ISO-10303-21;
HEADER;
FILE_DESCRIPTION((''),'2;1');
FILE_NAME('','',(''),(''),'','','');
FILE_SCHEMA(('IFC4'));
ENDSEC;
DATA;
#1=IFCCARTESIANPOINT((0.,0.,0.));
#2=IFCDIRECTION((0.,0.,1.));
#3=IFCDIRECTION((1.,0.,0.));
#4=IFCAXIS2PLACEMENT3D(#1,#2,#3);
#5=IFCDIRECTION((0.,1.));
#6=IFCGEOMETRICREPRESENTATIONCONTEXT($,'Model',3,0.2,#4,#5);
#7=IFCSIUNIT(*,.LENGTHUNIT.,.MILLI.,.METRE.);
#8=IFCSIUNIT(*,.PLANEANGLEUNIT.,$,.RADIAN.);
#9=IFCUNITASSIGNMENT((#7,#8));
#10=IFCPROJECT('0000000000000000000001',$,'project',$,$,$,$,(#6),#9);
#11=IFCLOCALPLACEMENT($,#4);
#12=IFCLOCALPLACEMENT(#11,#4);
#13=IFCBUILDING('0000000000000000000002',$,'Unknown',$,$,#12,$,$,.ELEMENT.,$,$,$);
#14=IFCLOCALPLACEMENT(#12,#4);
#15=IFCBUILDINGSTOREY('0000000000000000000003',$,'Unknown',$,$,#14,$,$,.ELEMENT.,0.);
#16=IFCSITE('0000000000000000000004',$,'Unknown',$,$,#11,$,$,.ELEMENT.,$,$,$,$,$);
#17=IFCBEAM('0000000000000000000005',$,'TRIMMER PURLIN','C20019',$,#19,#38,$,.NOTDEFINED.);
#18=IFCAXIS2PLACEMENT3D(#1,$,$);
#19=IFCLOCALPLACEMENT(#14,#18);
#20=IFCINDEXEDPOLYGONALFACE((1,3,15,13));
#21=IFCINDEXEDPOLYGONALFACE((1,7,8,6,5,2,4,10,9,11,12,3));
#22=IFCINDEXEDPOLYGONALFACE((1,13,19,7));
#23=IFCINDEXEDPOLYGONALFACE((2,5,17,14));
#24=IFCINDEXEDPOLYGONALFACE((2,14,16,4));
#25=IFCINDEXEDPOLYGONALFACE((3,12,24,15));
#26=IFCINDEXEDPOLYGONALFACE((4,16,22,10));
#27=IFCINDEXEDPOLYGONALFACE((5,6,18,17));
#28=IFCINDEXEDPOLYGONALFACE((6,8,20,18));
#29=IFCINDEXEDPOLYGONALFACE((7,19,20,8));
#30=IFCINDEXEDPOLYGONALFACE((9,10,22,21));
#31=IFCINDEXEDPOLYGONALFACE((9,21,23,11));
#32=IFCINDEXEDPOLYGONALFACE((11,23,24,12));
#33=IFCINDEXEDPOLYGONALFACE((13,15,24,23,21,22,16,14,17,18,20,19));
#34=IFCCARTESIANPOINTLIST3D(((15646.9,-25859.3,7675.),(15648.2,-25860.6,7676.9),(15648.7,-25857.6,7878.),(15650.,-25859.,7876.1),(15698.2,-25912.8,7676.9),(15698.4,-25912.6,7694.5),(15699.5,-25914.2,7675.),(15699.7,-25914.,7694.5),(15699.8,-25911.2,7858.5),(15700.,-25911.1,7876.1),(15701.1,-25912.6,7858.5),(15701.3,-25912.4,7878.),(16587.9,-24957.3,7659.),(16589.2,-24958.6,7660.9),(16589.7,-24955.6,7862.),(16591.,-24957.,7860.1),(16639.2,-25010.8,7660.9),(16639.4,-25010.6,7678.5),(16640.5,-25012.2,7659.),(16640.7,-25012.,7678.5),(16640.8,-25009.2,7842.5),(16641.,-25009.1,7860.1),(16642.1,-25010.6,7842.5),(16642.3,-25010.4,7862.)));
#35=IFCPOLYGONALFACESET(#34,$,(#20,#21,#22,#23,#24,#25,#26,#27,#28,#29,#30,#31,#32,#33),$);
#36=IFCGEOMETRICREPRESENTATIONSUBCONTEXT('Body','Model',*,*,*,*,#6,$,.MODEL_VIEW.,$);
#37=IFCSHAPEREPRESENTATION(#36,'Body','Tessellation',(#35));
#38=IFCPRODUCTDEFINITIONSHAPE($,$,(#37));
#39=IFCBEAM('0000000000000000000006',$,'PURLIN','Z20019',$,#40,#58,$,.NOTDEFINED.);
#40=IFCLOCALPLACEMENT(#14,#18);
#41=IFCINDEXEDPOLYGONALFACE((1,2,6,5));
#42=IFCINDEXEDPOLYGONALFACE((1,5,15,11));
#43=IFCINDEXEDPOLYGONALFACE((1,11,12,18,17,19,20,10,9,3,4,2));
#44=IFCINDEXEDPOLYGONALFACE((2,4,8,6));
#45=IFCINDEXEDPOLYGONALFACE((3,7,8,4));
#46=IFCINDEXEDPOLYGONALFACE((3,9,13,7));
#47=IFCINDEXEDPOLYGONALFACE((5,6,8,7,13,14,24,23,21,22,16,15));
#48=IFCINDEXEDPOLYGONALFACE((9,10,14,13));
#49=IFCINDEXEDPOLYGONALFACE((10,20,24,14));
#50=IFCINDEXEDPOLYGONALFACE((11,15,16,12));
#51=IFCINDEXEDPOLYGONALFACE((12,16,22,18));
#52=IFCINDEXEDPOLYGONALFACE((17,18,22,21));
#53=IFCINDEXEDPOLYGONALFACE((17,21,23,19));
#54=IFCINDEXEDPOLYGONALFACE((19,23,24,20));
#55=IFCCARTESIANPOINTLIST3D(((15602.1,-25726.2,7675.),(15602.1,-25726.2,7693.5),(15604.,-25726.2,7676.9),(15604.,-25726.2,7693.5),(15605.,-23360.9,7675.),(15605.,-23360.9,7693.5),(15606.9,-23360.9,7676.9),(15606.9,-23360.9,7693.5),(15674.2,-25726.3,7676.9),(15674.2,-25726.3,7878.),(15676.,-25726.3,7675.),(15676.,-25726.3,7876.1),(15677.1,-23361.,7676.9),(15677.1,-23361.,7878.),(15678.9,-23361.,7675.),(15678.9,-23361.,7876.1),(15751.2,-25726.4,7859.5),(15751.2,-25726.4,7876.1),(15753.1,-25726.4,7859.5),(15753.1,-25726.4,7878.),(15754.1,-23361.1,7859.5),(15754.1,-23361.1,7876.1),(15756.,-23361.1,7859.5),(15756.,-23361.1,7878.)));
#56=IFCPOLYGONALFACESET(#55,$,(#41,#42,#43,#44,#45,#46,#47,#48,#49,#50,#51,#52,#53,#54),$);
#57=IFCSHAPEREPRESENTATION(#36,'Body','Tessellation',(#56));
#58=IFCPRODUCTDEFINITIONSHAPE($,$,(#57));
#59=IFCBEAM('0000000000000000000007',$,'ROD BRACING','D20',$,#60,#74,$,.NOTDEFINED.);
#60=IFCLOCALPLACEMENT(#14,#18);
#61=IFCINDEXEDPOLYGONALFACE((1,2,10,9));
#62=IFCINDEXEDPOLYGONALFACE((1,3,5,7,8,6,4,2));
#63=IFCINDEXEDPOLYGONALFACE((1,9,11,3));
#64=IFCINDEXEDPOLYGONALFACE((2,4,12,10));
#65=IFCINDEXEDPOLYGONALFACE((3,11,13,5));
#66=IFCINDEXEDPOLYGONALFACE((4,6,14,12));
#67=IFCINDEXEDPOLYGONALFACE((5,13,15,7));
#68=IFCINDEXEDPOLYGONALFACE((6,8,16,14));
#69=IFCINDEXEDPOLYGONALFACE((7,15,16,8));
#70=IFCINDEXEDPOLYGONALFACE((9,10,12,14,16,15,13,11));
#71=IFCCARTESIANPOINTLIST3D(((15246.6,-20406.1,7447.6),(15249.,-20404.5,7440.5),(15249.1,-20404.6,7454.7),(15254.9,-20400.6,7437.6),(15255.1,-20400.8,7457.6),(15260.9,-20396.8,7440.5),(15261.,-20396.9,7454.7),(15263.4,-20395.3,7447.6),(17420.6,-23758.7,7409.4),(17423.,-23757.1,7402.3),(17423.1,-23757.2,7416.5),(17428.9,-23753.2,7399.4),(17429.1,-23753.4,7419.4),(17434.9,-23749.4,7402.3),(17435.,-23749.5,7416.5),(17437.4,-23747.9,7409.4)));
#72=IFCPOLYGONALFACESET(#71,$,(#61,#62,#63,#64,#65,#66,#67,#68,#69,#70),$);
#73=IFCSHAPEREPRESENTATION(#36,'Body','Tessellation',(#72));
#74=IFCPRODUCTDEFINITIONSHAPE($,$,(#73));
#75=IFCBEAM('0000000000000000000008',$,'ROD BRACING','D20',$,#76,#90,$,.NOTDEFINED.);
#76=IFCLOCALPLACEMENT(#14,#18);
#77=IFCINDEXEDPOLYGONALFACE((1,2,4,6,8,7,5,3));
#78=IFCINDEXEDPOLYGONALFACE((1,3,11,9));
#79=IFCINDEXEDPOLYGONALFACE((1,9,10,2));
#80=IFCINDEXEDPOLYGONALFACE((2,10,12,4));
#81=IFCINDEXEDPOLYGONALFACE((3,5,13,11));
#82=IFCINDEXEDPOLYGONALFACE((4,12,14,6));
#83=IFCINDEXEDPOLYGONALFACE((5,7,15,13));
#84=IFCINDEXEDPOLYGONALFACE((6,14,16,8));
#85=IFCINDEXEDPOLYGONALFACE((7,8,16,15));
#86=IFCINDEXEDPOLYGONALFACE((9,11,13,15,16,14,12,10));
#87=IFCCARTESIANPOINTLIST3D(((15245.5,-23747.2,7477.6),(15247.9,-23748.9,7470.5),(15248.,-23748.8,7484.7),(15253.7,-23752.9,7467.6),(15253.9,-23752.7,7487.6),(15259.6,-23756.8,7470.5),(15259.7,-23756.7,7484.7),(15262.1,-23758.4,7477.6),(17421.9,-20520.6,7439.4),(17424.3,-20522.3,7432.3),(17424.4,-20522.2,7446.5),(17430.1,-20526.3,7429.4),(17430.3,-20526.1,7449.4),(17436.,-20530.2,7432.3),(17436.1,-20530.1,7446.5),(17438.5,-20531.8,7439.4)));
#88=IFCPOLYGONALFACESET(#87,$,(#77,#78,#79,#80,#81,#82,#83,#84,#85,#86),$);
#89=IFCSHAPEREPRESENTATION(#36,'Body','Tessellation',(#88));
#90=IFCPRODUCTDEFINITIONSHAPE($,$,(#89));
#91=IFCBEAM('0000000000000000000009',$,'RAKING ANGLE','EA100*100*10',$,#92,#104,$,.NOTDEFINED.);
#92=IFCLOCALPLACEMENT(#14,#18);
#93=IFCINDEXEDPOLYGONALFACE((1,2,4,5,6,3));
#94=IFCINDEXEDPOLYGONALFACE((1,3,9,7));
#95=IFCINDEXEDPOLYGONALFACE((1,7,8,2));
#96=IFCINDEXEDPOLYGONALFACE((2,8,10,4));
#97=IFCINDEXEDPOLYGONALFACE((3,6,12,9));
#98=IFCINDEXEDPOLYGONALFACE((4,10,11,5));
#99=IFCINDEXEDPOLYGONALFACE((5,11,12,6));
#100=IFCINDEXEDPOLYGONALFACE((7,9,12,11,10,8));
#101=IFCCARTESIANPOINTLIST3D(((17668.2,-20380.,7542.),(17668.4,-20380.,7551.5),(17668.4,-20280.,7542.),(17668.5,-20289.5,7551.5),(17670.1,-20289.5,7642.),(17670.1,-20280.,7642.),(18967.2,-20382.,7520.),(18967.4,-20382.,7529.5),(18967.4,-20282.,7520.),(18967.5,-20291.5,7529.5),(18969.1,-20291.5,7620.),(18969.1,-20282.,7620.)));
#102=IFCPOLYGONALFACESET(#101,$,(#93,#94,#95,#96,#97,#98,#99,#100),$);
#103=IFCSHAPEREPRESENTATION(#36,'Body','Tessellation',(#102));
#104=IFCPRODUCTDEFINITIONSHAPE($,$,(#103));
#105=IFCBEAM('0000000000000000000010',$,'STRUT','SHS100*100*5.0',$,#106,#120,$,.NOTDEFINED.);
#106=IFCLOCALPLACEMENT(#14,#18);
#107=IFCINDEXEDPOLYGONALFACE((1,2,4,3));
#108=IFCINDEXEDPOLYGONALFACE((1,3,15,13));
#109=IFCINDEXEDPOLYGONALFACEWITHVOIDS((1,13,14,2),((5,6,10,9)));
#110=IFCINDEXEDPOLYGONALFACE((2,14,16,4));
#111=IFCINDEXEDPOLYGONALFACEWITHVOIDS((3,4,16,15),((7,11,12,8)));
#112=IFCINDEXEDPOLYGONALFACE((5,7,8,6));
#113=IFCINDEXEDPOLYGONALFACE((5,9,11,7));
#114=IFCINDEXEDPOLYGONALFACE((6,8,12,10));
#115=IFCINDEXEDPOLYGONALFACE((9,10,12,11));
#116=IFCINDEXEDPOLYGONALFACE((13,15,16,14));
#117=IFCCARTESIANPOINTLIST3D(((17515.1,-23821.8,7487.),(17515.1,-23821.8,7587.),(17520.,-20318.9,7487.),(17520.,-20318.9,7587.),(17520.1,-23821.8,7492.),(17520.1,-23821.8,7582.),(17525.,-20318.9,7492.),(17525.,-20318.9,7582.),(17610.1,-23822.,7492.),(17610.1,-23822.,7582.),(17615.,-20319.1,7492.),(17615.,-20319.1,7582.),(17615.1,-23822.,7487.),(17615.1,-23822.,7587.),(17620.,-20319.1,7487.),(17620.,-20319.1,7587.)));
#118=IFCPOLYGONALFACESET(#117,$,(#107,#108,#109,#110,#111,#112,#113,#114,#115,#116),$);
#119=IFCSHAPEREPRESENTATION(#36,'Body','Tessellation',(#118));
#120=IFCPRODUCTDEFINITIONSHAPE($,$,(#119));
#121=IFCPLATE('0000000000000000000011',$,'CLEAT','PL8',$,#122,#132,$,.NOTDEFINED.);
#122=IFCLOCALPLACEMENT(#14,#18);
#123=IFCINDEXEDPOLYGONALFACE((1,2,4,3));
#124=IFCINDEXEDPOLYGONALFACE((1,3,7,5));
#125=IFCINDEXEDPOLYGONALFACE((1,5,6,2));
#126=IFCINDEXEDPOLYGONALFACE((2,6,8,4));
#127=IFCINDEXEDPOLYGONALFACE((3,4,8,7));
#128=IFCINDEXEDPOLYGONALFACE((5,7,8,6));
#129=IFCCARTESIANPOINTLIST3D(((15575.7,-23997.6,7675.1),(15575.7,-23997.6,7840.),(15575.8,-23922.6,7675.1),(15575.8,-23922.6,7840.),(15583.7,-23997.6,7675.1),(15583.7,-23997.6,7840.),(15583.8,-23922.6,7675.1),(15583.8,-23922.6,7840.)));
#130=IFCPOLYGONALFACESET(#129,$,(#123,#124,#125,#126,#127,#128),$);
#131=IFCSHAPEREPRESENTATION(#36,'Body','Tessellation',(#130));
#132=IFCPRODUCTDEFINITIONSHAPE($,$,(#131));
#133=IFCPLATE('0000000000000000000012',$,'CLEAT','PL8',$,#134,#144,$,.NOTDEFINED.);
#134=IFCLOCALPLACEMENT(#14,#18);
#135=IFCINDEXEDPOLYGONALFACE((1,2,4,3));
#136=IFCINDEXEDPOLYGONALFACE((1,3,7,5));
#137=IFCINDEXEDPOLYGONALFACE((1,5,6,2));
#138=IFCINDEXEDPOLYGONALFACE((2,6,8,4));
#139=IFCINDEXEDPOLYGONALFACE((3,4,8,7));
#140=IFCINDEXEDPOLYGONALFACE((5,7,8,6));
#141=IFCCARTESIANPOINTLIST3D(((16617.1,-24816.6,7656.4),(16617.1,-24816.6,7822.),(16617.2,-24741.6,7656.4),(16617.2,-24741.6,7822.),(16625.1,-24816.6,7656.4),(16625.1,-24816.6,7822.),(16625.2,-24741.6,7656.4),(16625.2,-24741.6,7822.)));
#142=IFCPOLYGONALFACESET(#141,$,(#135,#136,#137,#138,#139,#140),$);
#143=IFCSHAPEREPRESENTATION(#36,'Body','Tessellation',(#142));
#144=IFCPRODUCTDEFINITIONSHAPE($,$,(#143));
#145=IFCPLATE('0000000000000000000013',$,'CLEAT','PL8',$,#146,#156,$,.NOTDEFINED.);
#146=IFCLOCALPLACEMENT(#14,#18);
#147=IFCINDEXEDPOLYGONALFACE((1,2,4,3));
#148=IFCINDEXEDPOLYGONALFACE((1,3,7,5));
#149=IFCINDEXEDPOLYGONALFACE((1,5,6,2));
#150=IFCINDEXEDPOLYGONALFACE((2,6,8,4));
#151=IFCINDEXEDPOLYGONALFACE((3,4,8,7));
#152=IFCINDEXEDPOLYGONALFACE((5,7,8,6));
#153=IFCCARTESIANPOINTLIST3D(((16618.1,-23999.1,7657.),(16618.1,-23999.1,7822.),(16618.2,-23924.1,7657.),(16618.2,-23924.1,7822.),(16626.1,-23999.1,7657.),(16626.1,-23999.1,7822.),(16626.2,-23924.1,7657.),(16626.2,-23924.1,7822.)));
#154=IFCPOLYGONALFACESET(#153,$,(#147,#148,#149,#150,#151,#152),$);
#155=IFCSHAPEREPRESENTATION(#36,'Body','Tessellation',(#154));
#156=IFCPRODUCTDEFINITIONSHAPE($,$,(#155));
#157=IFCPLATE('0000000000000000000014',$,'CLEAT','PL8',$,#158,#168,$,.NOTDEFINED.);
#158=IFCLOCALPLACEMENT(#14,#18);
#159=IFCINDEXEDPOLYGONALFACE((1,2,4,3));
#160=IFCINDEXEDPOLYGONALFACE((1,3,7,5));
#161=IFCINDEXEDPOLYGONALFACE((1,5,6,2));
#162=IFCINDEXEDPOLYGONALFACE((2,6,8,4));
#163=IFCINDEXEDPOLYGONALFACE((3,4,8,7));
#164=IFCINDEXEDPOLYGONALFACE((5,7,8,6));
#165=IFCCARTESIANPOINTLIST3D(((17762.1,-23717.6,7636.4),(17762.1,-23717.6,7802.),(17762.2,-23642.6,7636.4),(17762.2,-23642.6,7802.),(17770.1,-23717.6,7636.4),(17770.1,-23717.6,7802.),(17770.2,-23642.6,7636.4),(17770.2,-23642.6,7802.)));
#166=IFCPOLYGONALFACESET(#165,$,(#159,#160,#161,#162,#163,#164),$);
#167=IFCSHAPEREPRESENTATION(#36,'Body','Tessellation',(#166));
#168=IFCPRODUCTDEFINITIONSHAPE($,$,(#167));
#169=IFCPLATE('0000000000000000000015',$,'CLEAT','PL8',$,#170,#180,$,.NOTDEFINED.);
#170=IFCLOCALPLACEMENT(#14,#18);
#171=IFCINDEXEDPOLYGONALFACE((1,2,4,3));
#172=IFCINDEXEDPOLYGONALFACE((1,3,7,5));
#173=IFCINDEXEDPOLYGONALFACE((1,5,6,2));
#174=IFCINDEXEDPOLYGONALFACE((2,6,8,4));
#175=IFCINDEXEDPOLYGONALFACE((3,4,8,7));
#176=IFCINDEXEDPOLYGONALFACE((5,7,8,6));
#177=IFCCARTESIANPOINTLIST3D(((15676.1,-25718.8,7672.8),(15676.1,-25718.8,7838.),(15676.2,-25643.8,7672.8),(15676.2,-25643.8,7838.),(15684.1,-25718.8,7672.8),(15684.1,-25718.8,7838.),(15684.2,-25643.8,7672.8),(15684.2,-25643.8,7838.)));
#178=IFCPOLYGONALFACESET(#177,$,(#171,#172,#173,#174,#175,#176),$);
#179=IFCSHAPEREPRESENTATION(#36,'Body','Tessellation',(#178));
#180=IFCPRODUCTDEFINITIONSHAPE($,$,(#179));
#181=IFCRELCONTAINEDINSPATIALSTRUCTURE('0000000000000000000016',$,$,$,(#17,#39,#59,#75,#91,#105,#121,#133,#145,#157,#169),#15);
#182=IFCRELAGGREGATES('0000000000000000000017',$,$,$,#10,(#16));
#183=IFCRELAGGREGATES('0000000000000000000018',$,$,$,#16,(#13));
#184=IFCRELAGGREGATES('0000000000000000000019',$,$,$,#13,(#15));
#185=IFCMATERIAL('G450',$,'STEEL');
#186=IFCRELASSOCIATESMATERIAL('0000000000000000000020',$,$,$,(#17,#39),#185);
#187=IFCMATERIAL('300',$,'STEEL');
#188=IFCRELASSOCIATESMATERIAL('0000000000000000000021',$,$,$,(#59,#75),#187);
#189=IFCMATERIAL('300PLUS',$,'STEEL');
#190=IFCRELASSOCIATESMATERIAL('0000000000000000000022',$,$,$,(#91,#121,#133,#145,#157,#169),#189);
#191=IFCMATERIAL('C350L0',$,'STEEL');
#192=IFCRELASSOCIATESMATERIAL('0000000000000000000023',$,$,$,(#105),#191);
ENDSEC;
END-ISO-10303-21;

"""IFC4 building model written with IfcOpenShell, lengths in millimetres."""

from ifc_helpers import new_model, si_unit, direction, frame, origin_with_axes, place, context, subcontext, project, spatial, line, indexed_curve, outline, extrude, material, element, save


model = new_model("IFC4")

# Units and contexts
model_context = context("Model", 3, precision=0.2, world=origin_with_axes(), true_north=direction((0.0, 1.0)))
body_context = subcontext(model_context, "Body", "Model", "MODEL_VIEW")
ifc_project = project(units=[si_unit("LENGTHUNIT", "METRE", prefix="MILLI"), si_unit("PLANEANGLEUNIT", "RADIAN")], contexts=[model_context])

# Site, building, storey
site_placement = place(None, origin_with_axes())
site = spatial("IfcSite", under=ifc_project, at=site_placement, Name="Unknown", CompositionType="ELEMENT")
building_placement = place(site_placement, origin_with_axes())
building = spatial("IfcBuilding", under=site, at=building_placement, Name="Unknown", CompositionType="ELEMENT")
storey_placement = place(building_placement, origin_with_axes())
storey = spatial("IfcBuildingStorey", under=building, at=storey_placement, Name="Unknown", CompositionType="ELEMENT", Elevation=0.0)

# Beams
ifc_material_1 = material(Name="G450", Category="STEEL")
beam_1_placement = place(storey_placement, frame((15674.1, -25885.9, 7776.5), z_axis=(0.691989, -0.721908, 0.0), x_axis=(0.721854, 0.691937, -0.012274)))
element("IfcBeam", 1, at=beam_1_placement, inside=storey, material=ifc_material_1, Name="TRIMMER PURLIN", Description="C20019", PredefinedType="NOTDEFINED", context=body_context, shape_type="SolidModel", body=[
    extrude(outline(indexed_curve([(38.0, -101.5), (38.0, -82.0), (36.1, -82.0), (36.1, -99.6), (-36.1, -99.6), (-36.1, 99.6), (36.1, 99.6), (36.1, 82.0), (38.0, 82.0), (38.0, 101.5), (-38.0, 101.5), (-38.0, -101.5)], segments=[line(1, 2, 3, 4, 5, 6, 7, 8, 9, 10, 11, 12, 1)])), frame((0.0, 0.0, 0.0), z_axis=(-1.0, 0.0, 0.0), x_axis=(0.0, 0.0, 1.0)), (0.0, 0.0, -1.0), 1303.6),
])
beam_2_placement = place(storey_placement, frame((15678.0, -23361.0, 7776.5), z_axis=(-0.999999, 0.001226, 0.0), x_axis=(-0.001226, -0.999999, 0.0)))
element("IfcBeam", 2, at=beam_2_placement, inside=storey, material=ifc_material_1, Name="PURLIN", Description="Z20019", PredefinedType="NOTDEFINED", context=body_context, shape_type="SolidModel", body=[
    extrude(outline(indexed_curve([(73.0, -101.5), (73.0, -83.0), (71.2, -83.0), (71.2, -99.6), (0.9, -99.6), (0.9, 101.5), (-78.0, 101.5), (-78.0, 83.0), (-76.2, 83.0), (-76.2, 99.6), (-0.9, 99.6), (-0.9, -101.5)], segments=[line(1, 2, 3, 4, 5, 6, 7, 8, 9, 10, 11, 12, 1)])), frame((0.0, 0.0, 0.0), z_axis=(-1.0, 0.0, 0.0), x_axis=(0.0, 0.0, 1.0)), (0.0, 0.0, -1.0), 2365.3),
])
ifc_material_2 = material(Name="300", Category="STEEL")
beam_3_placement = place(storey_placement, frame((17429.0, -23753.3, 7409.4), z_axis=(0.005201, -0.008021, 0.999954), x_axis=(-0.54405, 0.838998, 0.00956)))
element("IfcBeam", 3, at=beam_3_placement, inside=storey, material=ifc_material_2, Name="ROD BRACING", Description="D20", PredefinedType="NOTDEFINED", context=body_context, shape_type="SolidModel", body=[
    extrude(outline(indexed_curve([(10.0, 0.0), (7.1, 7.1), (0.0, 10.0), (-7.1, 7.1), (-10.0, 0.0), (-7.1, -7.1), (0.0, -10.0), (7.1, -7.1)], segments=[line(1, 2, 3, 4, 5, 6, 7, 8, 1)])), frame((0.0, 0.0, 0.0), z_axis=(-1.0, 0.0, 0.0), x_axis=(0.0, 0.0, 1.0)), (0.0, 0.0, -1.0), 3996.0),
])
beam_4_placement = place(storey_placement, frame((15253.8, -23752.8, 7477.6), z_axis=(0.005488, 0.008137, 0.999952), x_axis=(0.559171, 0.828994, -0.009815)))
element("IfcBeam", 4, at=beam_4_placement, inside=storey, material=ifc_material_2, Name="ROD BRACING", Description="D20", PredefinedType="NOTDEFINED", context=body_context, shape_type="SolidModel", body=[
    extrude(outline(indexed_curve([(10.0, 0.0), (7.1, 7.1), (0.0, 10.0), (-7.1, 7.1), (-10.0, 0.0), (-7.1, -7.1), (0.0, -10.0), (7.1, -7.1)], segments=[line(1, 2, 3, 4, 5, 6, 7, 8, 1)])), frame((0.0, 0.0, 0.0), z_axis=(-1.0, 0.0, 0.0), x_axis=(0.0, 0.0, 1.0)), (0.0, 0.0, -1.0), 3892.2),
])
ifc_material_3 = material(Name="300PLUS", Category="STEEL")
beam_5_placement = place(storey_placement, frame((17669.2, -20330.0, 7592.0), z_axis=(-0.00154, -0.999999, 0.0), x_axis=(0.999855, -0.001539, -0.016934)))
element("IfcBeam", 5, at=beam_5_placement, inside=storey, material=ifc_material_3, Name="RAKING ANGLE", Description="EA100*100*10", PredefinedType="NOTDEFINED", context=body_context, shape_type="SolidModel", body=[
    extrude(outline(indexed_curve([(-50.0, -50.0), (50.0, -50.0), (50.0, -40.5), (-40.5, -40.5), (-40.5, 50.0), (-50.0, 50.0)], segments=[line(1, 2, 3, 4, 5, 6, 1)])), frame((0.0, 0.0, 0.0), z_axis=(-1.0, 0.0, 0.0), x_axis=(0.0, 0.0, 1.0)), (0.0, 0.0, -1.0), 1299.2),
])
ifc_material_4 = material(Name="C350L0", Category="STEEL")
beam_6_placement = place(storey_placement, frame((17570.0, -20319.0, 7537.0), z_axis=(0.0, 0.0, 1.0), x_axis=(-0.001399, -0.999999, 0.0)))
element("IfcBeam", 6, at=beam_6_placement, inside=storey, material=ifc_material_4, Name="STRUT", Description="SHS100*100*5.0", PredefinedType="NOTDEFINED", context=body_context, shape_type="SolidModel", body=[
    extrude(outline(indexed_curve([(-50.0, -50.0), (50.0, -50.0), (50.0, 50.0), (-50.0, 50.0)], segments=[line(1, 2, 3, 4, 1)]), holes=[indexed_curve([(-45.0, -45.0), (-45.0, 45.0), (45.0, 45.0), (45.0, -45.0)], segments=[line(1, 2, 3, 4, 1)])]), frame((0.0, 0.0, 0.0), z_axis=(-1.0, 0.0, 0.0), x_axis=(0.0, 0.0, 1.0)), (0.0, 0.0, -1.0), 3502.9),
])

# Plates
plate_1_placement = place(storey_placement, frame((15579.8, -23922.6, 7840.0), z_axis=(0.999999, -0.001333, 0.0), x_axis=(-0.001333, -0.999999, 0.0)))
element("IfcPlate", 7, at=plate_1_placement, inside=storey, material=ifc_material_3, Name="CLEAT", Description="PL8", PredefinedType="NOTDEFINED", context=body_context, shape_type="SolidModel", body=[
    extrude(outline(indexed_curve([(0.0, 0.0), (75.0, 0.0), (75.0, 164.9), (0.0, 164.9)], segments=[line(1, 2, 3, 4, 1)])), frame((0.0, 0.0, 4.0), z_axis=(0.0, 0.0, 1.0), x_axis=(1.0, 0.0, 0.0)), (0.0, 0.0, -1.0), 8.0),
])
plate_2_placement = place(storey_placement, frame((16621.2, -24741.6, 7822.0), z_axis=(0.999999, -0.001333, 0.0), x_axis=(-0.001333, -0.999999, 0.0)))
element("IfcPlate", 8, at=plate_2_placement, inside=storey, material=ifc_material_3, Name="CLEAT", Description="PL8", PredefinedType="NOTDEFINED", context=body_context, shape_type="SolidModel", body=[
    extrude(outline(indexed_curve([(0.0, 0.0), (75.0, 0.0), (75.0, 165.6), (0.0, 165.6)], segments=[line(1, 2, 3, 4, 1)])), frame((0.0, 0.0, 4.0), z_axis=(0.0, 0.0, 1.0), x_axis=(1.0, 0.0, 0.0)), (0.0, 0.0, -1.0), 8.0),
])
plate_3_placement = place(storey_placement, frame((16622.2, -23924.1, 7822.0), z_axis=(0.999999, -0.001333, 0.0), x_axis=(-0.001333, -0.999999, 0.0)))
element("IfcPlate", 9, at=plate_3_placement, inside=storey, material=ifc_material_3, Name="CLEAT", Description="PL8", PredefinedType="NOTDEFINED", context=body_context, shape_type="SolidModel", body=[
    extrude(outline(indexed_curve([(0.0, 0.0), (75.0, 0.0), (75.0, 165.0), (0.0, 165.0)], segments=[line(1, 2, 3, 4, 1)])), frame((0.0, 0.0, 4.0), z_axis=(0.0, 0.0, 1.0), x_axis=(1.0, 0.0, 0.0)), (0.0, 0.0, -1.0), 8.0),
])
plate_4_placement = place(storey_placement, frame((17766.2, -23642.6, 7802.0), z_axis=(0.999999, -0.001333, 0.0), x_axis=(-0.001333, -0.999999, 0.0)))
element("IfcPlate", 10, at=plate_4_placement, inside=storey, material=ifc_material_3, Name="CLEAT", Description="PL8", PredefinedType="NOTDEFINED", context=body_context, shape_type="SolidModel", body=[
    extrude(outline(indexed_curve([(0.0, 0.0), (75.0, 0.0), (75.0, 165.6), (0.0, 165.6)], segments=[line(1, 2, 3, 4, 1)])), frame((0.0, 0.0, 4.0), z_axis=(0.0, 0.0, 1.0), x_axis=(1.0, 0.0, 0.0)), (0.0, 0.0, -1.0), 8.0),
])
plate_5_placement = place(storey_placement, frame((15680.2, -25643.8, 7838.0), z_axis=(0.999999, -0.001333, 0.0), x_axis=(-0.001333, -0.999999, 0.0)))
element("IfcPlate", 11, at=plate_5_placement, inside=storey, material=ifc_material_3, Name="CLEAT", Description="PL8", PredefinedType="NOTDEFINED", context=body_context, shape_type="SolidModel", body=[
    extrude(outline(indexed_curve([(0.0, 0.0), (75.0, 0.0), (75.0, 165.2), (0.0, 165.2)], segments=[line(1, 2, 3, 4, 1)])), frame((0.0, 0.0, 4.0), z_axis=(0.0, 0.0, 1.0), x_axis=(1.0, 0.0, 0.0)), (0.0, 0.0, -1.0), 8.0),
])

save(model, "model.ifc")
